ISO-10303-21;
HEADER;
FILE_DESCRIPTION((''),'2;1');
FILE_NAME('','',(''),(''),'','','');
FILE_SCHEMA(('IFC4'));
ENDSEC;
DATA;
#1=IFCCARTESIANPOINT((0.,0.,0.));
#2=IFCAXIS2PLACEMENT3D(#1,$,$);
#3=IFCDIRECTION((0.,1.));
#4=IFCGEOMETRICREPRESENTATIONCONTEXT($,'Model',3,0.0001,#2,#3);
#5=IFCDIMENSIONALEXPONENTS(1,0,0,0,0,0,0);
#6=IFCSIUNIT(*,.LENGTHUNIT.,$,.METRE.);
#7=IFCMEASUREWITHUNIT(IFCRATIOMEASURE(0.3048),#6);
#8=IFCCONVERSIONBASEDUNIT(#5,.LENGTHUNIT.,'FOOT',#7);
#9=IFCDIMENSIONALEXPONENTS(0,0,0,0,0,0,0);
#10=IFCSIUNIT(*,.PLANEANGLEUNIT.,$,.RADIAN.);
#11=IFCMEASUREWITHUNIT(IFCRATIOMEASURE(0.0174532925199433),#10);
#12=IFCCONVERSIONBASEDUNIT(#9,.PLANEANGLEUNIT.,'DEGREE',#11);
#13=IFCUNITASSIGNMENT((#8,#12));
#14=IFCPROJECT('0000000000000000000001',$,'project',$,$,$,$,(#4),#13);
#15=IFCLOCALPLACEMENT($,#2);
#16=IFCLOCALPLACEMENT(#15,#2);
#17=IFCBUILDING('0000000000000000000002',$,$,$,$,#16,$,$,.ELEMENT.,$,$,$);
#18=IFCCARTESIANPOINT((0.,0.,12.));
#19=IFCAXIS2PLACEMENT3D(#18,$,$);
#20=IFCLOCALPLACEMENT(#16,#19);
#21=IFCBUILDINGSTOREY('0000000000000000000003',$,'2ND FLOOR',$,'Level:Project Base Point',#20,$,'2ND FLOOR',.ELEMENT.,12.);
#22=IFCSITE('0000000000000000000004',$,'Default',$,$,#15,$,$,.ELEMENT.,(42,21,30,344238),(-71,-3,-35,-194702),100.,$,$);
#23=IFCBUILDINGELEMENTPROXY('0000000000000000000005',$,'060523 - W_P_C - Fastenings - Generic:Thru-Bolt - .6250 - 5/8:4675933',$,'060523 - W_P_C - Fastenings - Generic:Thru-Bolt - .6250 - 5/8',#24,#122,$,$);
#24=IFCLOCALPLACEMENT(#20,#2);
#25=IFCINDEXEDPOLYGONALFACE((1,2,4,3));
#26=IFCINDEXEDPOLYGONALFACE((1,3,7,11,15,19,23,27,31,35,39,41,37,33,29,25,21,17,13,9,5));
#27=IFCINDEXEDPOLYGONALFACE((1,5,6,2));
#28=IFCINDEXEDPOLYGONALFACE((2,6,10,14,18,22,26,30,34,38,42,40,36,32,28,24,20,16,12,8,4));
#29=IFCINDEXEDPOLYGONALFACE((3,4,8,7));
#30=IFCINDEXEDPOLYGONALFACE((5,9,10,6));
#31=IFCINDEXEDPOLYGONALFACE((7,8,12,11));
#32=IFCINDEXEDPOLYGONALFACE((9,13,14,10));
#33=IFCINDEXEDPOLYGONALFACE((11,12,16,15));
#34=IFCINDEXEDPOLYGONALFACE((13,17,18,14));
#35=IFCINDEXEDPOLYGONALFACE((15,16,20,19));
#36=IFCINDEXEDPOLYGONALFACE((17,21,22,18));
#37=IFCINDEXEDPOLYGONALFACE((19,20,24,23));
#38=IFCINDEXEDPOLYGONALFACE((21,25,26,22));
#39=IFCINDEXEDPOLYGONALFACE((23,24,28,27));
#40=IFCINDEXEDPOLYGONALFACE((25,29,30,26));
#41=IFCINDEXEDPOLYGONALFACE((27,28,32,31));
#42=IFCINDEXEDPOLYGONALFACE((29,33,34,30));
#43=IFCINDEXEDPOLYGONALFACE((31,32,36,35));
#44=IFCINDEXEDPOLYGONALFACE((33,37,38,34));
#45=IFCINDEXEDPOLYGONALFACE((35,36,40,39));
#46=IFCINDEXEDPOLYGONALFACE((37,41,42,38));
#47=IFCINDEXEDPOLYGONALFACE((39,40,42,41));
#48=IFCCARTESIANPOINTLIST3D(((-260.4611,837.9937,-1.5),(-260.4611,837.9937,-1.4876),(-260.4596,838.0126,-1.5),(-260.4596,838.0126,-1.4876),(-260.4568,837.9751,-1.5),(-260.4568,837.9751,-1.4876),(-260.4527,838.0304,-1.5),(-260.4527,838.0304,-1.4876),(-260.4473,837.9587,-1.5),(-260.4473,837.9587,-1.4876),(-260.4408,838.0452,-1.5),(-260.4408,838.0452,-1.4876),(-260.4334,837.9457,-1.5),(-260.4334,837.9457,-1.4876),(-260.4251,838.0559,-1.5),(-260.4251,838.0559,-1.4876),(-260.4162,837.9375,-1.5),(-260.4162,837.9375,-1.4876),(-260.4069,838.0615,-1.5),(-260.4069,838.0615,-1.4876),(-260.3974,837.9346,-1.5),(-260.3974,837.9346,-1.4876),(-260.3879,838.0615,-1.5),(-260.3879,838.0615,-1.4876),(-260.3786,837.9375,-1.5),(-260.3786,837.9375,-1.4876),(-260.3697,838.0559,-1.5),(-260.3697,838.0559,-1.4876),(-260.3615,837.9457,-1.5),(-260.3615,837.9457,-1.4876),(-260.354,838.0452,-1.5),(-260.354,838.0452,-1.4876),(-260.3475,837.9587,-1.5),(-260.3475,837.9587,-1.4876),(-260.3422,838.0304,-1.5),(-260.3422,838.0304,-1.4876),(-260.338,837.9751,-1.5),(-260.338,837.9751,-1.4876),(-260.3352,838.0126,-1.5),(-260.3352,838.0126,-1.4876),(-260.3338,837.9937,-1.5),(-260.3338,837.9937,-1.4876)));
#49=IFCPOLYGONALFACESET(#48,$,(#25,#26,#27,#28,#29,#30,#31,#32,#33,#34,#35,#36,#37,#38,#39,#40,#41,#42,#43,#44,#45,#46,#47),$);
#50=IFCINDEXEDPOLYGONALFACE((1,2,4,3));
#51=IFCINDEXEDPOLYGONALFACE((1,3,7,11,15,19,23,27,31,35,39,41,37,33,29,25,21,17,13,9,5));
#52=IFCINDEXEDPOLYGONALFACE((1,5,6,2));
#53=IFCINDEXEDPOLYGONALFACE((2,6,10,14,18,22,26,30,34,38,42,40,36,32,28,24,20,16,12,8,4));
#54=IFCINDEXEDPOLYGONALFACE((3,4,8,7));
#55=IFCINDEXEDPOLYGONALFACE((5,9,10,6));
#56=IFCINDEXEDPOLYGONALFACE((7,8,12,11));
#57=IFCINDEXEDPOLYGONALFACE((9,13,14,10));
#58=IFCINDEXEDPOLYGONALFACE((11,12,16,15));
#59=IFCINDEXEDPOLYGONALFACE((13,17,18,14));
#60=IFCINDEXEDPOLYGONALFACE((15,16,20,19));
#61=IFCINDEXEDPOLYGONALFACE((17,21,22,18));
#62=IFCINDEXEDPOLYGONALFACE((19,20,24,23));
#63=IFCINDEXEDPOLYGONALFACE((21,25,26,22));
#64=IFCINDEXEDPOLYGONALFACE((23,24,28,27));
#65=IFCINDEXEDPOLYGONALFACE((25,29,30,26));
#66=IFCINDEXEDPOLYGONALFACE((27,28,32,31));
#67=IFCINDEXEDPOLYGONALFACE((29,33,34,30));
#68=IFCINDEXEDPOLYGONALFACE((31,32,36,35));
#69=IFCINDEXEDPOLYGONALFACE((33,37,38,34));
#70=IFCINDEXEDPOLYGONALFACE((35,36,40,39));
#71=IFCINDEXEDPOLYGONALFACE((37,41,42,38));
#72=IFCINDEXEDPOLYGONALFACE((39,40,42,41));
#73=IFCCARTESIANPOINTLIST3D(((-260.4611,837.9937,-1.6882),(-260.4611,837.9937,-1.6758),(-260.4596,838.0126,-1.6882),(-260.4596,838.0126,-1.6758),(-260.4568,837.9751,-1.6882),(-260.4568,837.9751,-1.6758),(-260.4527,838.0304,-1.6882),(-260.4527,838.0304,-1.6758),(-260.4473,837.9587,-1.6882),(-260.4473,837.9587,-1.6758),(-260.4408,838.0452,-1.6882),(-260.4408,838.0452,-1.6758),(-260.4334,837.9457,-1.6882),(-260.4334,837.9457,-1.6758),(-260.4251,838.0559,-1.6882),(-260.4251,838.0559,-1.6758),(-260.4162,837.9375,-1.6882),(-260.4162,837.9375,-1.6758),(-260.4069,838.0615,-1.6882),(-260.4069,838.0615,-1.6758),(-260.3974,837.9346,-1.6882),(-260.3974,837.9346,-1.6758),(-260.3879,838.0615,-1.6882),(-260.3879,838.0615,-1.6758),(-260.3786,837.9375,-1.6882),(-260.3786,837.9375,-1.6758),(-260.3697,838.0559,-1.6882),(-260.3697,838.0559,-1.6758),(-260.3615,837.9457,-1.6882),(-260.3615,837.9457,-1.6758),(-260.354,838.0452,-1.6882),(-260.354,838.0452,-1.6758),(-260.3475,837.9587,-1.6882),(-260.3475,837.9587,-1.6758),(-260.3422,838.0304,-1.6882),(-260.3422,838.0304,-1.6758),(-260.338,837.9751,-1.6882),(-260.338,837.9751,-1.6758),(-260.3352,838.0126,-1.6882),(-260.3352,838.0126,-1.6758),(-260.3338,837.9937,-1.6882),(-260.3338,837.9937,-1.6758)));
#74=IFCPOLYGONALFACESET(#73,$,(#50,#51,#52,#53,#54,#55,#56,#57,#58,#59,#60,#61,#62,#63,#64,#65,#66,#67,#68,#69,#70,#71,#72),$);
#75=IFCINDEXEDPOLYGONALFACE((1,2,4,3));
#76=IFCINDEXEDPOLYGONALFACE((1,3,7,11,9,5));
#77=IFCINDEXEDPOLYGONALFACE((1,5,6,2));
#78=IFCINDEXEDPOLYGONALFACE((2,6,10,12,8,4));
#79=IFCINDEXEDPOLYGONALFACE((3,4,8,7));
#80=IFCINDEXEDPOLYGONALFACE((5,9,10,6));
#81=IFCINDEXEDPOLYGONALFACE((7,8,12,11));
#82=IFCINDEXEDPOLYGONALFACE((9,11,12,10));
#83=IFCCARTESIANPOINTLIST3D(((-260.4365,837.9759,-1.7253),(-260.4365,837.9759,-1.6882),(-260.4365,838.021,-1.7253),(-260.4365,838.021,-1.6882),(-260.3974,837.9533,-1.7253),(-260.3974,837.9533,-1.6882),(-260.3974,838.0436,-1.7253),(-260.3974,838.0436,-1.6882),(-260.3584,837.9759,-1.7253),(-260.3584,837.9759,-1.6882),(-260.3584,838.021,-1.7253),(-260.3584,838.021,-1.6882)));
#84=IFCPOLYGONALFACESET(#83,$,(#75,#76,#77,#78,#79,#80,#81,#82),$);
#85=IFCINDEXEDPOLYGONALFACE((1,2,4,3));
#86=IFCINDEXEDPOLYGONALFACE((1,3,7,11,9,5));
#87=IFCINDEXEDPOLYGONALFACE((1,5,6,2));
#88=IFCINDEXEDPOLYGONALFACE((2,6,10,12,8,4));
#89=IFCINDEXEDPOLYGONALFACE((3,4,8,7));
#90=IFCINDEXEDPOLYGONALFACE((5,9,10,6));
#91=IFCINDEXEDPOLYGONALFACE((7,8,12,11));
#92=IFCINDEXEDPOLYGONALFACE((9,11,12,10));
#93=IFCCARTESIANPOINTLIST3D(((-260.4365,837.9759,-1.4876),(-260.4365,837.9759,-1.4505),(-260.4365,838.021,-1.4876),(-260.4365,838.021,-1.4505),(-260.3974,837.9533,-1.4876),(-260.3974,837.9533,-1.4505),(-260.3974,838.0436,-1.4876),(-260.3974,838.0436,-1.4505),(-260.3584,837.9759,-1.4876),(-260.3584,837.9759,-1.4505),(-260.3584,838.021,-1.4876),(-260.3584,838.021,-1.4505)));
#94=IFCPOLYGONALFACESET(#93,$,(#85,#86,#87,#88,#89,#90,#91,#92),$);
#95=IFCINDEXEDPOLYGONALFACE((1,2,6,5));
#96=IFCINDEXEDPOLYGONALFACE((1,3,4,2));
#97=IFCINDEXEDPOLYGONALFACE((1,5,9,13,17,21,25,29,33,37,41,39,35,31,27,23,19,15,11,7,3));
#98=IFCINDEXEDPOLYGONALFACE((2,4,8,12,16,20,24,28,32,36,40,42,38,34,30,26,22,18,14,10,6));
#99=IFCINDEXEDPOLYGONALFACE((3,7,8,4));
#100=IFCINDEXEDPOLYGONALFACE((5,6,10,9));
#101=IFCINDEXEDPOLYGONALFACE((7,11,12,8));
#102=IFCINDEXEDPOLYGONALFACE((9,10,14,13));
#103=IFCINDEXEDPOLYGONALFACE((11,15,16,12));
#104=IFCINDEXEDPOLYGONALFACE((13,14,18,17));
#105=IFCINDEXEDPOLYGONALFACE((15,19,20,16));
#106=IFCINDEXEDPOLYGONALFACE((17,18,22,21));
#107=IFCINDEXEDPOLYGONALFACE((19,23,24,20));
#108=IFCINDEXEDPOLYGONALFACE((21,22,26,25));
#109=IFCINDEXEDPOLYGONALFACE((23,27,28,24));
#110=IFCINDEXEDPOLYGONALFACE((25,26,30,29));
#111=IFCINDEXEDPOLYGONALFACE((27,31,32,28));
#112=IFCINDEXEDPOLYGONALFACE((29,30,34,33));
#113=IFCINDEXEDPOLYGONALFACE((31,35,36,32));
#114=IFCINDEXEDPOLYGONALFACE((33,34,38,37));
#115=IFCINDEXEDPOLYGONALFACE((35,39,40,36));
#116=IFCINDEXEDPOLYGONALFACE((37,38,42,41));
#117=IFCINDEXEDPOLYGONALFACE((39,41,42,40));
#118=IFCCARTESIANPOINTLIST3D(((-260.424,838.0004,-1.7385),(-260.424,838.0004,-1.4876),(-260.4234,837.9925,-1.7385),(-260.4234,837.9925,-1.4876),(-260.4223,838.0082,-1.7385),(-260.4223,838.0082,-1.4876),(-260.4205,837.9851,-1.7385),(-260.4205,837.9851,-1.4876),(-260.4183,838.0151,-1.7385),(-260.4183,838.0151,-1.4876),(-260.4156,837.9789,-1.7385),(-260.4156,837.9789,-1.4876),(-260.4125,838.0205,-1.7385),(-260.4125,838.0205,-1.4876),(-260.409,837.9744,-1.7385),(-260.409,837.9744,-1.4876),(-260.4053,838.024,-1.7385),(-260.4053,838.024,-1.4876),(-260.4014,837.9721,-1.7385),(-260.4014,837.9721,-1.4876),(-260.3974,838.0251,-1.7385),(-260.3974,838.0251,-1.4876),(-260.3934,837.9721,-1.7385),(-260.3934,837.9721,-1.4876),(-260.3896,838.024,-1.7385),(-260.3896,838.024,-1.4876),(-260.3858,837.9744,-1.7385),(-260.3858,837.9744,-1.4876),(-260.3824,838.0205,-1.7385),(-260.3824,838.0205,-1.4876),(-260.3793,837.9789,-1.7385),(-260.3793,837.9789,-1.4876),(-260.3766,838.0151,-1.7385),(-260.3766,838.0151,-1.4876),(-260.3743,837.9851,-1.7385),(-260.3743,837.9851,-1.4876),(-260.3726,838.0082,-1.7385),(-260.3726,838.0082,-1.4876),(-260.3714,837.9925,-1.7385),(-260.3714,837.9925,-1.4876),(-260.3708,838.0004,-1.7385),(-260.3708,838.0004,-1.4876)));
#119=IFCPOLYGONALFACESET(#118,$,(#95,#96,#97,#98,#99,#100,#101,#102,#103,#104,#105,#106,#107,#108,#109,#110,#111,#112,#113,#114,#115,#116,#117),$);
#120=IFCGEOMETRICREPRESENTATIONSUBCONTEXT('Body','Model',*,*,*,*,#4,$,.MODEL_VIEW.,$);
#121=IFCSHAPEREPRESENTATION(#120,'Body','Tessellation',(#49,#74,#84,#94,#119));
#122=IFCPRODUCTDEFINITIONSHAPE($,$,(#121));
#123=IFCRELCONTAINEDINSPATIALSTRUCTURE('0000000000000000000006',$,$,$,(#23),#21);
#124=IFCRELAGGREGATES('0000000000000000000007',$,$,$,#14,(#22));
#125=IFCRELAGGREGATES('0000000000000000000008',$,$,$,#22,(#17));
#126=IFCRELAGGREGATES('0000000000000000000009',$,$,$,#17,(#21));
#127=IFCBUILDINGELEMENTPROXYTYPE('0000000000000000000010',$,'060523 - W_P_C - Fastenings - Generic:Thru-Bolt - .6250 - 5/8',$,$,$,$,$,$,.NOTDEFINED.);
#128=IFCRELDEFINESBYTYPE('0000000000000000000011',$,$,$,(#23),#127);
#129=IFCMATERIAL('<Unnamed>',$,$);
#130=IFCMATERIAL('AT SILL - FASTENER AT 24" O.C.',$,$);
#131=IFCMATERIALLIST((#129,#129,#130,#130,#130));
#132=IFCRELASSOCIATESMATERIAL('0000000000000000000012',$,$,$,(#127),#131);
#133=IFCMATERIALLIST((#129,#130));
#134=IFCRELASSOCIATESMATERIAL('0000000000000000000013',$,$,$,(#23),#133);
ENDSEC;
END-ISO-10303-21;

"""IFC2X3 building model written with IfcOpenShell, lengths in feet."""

from ifc_helpers import new_model, entity, si_unit, converted_unit, direction, frame, frame_2d, origin, place, context, subcontext, project, spatial, polyline, circle, outline, extrude, source, transform, mapped, material, material_list, type_object, type_shapes, element, save


model = new_model("IFC2X3")

# Units and contexts
model_context = context("Model", 3, precision=0.0001, world=origin(), true_north=direction((0.0, 1.0)))
body_context = subcontext(model_context, "Body", "Model", "MODEL_VIEW")
ifc_project = project(units=[converted_unit("LENGTHUNIT", "FOOT", entity("IfcRatioMeasure", 0.3048), si_unit("LENGTHUNIT", "METRE"), dimensions=[1, 0, 0, 0, 0, 0, 0]), converted_unit("PLANEANGLEUNIT", "DEGREE", entity("IfcRatioMeasure", 0.0174532925199433), si_unit("PLANEANGLEUNIT", "RADIAN"), dimensions=[0, 0, 0, 0, 0, 0, 0])], contexts=[model_context])

# Site, building, storey
site_placement = place(None, origin())
site = spatial("IfcSite", under=ifc_project, at=site_placement, Name="Default", CompositionType="ELEMENT", RefLatitude=(42, 21, 30, 344238), RefLongitude=(-71, -3, -35, -194702), RefElevation=100.0)
building_placement = place(site_placement, origin())
building = spatial("IfcBuilding", under=site, at=building_placement, CompositionType="ELEMENT")
storey_placement = place(building_placement, frame((0.0, 0.0, 12.0)))
storey = spatial("IfcBuildingStorey", under=building, at=storey_placement, Name="2ND FLOOR", ObjectType="Level:Project Base Point", LongName="2ND FLOOR", CompositionType="ELEMENT", Elevation=12.0)

# Building element proxy
ifc_material_1 = material(Name="<Unnamed>")
ifc_material_2 = material(Name="AT SILL - FASTENER AT 24\" O.C.")
ifc_material_list_1 = material_list([ifc_material_1, ifc_material_1, ifc_material_2, ifc_material_2, ifc_material_2])
building_element_proxy_type_1 = type_object("IfcBuildingElementProxyType", Name="060523 - W_P_C - Fastenings - Generic:Thru-Bolt - .6250 - 5/8", PredefinedType="NOTDEFINED", material=ifc_material_list_1)
shared_shape_1 = source(origin(), body_context, "Body", "SweptSolid", [
    extrude(circle(Radius=0.0638, at=frame_2d((0.0, 0.0), x_axis=(1.0, 0.0))), frame((0.0, 0.0, 0.0), z_axis=(0.0, 0.0, 1.0), x_axis=(0.0, -1.0, 0.0)), (0.0, 0.0, 1.0), 0.0124),
    extrude(circle(Radius=0.0638, at=frame_2d((0.0, 0.0), x_axis=(1.0, 0.0))), frame((0.0, 0.0, -0.1882), z_axis=(0.0, 0.0, 1.0), x_axis=(0.0, -1.0, 0.0)), (0.0, 0.0, 1.0), 0.0124),
    extrude(outline(polyline([(-0.0226, -0.0391), (0.0226, -0.0391), (0.0451, 0.0), (0.0226, 0.0391), (-0.0226, 0.0391), (-0.0451, 0.0), (-0.0226, -0.0391)])), frame((0.0, 0.0, -0.2253), z_axis=(0.0, 0.0, 1.0), x_axis=(0.866025, -0.5, 0.0)), (0.0, 0.0, 1.0), 0.0371),
    extrude(outline(polyline([(-0.0226, -0.0391), (0.0226, -0.0391), (0.0451, 0.0), (0.0226, 0.0391), (-0.0226, 0.0391), (-0.0451, 0.0), (-0.0226, -0.0391)])), frame((0.0, 0.0, 0.0124), z_axis=(0.0, 0.0, 1.0), x_axis=(0.0, -1.0, 0.0)), (0.0, 0.0, 1.0), 0.0371),
    extrude(circle(Radius=0.0267, at=frame_2d((0.0, 0.0), x_axis=(1.0, 0.0))), frame((0.0, 0.0, -0.2385), z_axis=(0.0, 0.0, 1.0), x_axis=(0.0, 1.0, 0.0)), (0.0, 0.0, 1.0), 0.2509),
])
type_shapes(building_element_proxy_type_1, [shared_shape_1])
ifc_material_list_2 = material_list([ifc_material_1, ifc_material_2])
proxy_1_placement = place(storey_placement, frame((-260.3974, 837.9985, -1.5)))
element("IfcBuildingElementProxy", 1, at=proxy_1_placement, inside=storey, type_object=building_element_proxy_type_1, material=ifc_material_list_2, Name="060523 - W_P_C - Fastenings - Generic:Thru-Bolt - .6250 - 5/8:4675933", ObjectType="060523 - W_P_C - Fastenings - Generic:Thru-Bolt - .6250 - 5/8", context=body_context, shape_type="MappedRepresentation", body=[
    mapped(shared_shape_1, transform((0.0, 0.0, 0.0), scale=1.0)),
])

save(model, "model.ifc")
